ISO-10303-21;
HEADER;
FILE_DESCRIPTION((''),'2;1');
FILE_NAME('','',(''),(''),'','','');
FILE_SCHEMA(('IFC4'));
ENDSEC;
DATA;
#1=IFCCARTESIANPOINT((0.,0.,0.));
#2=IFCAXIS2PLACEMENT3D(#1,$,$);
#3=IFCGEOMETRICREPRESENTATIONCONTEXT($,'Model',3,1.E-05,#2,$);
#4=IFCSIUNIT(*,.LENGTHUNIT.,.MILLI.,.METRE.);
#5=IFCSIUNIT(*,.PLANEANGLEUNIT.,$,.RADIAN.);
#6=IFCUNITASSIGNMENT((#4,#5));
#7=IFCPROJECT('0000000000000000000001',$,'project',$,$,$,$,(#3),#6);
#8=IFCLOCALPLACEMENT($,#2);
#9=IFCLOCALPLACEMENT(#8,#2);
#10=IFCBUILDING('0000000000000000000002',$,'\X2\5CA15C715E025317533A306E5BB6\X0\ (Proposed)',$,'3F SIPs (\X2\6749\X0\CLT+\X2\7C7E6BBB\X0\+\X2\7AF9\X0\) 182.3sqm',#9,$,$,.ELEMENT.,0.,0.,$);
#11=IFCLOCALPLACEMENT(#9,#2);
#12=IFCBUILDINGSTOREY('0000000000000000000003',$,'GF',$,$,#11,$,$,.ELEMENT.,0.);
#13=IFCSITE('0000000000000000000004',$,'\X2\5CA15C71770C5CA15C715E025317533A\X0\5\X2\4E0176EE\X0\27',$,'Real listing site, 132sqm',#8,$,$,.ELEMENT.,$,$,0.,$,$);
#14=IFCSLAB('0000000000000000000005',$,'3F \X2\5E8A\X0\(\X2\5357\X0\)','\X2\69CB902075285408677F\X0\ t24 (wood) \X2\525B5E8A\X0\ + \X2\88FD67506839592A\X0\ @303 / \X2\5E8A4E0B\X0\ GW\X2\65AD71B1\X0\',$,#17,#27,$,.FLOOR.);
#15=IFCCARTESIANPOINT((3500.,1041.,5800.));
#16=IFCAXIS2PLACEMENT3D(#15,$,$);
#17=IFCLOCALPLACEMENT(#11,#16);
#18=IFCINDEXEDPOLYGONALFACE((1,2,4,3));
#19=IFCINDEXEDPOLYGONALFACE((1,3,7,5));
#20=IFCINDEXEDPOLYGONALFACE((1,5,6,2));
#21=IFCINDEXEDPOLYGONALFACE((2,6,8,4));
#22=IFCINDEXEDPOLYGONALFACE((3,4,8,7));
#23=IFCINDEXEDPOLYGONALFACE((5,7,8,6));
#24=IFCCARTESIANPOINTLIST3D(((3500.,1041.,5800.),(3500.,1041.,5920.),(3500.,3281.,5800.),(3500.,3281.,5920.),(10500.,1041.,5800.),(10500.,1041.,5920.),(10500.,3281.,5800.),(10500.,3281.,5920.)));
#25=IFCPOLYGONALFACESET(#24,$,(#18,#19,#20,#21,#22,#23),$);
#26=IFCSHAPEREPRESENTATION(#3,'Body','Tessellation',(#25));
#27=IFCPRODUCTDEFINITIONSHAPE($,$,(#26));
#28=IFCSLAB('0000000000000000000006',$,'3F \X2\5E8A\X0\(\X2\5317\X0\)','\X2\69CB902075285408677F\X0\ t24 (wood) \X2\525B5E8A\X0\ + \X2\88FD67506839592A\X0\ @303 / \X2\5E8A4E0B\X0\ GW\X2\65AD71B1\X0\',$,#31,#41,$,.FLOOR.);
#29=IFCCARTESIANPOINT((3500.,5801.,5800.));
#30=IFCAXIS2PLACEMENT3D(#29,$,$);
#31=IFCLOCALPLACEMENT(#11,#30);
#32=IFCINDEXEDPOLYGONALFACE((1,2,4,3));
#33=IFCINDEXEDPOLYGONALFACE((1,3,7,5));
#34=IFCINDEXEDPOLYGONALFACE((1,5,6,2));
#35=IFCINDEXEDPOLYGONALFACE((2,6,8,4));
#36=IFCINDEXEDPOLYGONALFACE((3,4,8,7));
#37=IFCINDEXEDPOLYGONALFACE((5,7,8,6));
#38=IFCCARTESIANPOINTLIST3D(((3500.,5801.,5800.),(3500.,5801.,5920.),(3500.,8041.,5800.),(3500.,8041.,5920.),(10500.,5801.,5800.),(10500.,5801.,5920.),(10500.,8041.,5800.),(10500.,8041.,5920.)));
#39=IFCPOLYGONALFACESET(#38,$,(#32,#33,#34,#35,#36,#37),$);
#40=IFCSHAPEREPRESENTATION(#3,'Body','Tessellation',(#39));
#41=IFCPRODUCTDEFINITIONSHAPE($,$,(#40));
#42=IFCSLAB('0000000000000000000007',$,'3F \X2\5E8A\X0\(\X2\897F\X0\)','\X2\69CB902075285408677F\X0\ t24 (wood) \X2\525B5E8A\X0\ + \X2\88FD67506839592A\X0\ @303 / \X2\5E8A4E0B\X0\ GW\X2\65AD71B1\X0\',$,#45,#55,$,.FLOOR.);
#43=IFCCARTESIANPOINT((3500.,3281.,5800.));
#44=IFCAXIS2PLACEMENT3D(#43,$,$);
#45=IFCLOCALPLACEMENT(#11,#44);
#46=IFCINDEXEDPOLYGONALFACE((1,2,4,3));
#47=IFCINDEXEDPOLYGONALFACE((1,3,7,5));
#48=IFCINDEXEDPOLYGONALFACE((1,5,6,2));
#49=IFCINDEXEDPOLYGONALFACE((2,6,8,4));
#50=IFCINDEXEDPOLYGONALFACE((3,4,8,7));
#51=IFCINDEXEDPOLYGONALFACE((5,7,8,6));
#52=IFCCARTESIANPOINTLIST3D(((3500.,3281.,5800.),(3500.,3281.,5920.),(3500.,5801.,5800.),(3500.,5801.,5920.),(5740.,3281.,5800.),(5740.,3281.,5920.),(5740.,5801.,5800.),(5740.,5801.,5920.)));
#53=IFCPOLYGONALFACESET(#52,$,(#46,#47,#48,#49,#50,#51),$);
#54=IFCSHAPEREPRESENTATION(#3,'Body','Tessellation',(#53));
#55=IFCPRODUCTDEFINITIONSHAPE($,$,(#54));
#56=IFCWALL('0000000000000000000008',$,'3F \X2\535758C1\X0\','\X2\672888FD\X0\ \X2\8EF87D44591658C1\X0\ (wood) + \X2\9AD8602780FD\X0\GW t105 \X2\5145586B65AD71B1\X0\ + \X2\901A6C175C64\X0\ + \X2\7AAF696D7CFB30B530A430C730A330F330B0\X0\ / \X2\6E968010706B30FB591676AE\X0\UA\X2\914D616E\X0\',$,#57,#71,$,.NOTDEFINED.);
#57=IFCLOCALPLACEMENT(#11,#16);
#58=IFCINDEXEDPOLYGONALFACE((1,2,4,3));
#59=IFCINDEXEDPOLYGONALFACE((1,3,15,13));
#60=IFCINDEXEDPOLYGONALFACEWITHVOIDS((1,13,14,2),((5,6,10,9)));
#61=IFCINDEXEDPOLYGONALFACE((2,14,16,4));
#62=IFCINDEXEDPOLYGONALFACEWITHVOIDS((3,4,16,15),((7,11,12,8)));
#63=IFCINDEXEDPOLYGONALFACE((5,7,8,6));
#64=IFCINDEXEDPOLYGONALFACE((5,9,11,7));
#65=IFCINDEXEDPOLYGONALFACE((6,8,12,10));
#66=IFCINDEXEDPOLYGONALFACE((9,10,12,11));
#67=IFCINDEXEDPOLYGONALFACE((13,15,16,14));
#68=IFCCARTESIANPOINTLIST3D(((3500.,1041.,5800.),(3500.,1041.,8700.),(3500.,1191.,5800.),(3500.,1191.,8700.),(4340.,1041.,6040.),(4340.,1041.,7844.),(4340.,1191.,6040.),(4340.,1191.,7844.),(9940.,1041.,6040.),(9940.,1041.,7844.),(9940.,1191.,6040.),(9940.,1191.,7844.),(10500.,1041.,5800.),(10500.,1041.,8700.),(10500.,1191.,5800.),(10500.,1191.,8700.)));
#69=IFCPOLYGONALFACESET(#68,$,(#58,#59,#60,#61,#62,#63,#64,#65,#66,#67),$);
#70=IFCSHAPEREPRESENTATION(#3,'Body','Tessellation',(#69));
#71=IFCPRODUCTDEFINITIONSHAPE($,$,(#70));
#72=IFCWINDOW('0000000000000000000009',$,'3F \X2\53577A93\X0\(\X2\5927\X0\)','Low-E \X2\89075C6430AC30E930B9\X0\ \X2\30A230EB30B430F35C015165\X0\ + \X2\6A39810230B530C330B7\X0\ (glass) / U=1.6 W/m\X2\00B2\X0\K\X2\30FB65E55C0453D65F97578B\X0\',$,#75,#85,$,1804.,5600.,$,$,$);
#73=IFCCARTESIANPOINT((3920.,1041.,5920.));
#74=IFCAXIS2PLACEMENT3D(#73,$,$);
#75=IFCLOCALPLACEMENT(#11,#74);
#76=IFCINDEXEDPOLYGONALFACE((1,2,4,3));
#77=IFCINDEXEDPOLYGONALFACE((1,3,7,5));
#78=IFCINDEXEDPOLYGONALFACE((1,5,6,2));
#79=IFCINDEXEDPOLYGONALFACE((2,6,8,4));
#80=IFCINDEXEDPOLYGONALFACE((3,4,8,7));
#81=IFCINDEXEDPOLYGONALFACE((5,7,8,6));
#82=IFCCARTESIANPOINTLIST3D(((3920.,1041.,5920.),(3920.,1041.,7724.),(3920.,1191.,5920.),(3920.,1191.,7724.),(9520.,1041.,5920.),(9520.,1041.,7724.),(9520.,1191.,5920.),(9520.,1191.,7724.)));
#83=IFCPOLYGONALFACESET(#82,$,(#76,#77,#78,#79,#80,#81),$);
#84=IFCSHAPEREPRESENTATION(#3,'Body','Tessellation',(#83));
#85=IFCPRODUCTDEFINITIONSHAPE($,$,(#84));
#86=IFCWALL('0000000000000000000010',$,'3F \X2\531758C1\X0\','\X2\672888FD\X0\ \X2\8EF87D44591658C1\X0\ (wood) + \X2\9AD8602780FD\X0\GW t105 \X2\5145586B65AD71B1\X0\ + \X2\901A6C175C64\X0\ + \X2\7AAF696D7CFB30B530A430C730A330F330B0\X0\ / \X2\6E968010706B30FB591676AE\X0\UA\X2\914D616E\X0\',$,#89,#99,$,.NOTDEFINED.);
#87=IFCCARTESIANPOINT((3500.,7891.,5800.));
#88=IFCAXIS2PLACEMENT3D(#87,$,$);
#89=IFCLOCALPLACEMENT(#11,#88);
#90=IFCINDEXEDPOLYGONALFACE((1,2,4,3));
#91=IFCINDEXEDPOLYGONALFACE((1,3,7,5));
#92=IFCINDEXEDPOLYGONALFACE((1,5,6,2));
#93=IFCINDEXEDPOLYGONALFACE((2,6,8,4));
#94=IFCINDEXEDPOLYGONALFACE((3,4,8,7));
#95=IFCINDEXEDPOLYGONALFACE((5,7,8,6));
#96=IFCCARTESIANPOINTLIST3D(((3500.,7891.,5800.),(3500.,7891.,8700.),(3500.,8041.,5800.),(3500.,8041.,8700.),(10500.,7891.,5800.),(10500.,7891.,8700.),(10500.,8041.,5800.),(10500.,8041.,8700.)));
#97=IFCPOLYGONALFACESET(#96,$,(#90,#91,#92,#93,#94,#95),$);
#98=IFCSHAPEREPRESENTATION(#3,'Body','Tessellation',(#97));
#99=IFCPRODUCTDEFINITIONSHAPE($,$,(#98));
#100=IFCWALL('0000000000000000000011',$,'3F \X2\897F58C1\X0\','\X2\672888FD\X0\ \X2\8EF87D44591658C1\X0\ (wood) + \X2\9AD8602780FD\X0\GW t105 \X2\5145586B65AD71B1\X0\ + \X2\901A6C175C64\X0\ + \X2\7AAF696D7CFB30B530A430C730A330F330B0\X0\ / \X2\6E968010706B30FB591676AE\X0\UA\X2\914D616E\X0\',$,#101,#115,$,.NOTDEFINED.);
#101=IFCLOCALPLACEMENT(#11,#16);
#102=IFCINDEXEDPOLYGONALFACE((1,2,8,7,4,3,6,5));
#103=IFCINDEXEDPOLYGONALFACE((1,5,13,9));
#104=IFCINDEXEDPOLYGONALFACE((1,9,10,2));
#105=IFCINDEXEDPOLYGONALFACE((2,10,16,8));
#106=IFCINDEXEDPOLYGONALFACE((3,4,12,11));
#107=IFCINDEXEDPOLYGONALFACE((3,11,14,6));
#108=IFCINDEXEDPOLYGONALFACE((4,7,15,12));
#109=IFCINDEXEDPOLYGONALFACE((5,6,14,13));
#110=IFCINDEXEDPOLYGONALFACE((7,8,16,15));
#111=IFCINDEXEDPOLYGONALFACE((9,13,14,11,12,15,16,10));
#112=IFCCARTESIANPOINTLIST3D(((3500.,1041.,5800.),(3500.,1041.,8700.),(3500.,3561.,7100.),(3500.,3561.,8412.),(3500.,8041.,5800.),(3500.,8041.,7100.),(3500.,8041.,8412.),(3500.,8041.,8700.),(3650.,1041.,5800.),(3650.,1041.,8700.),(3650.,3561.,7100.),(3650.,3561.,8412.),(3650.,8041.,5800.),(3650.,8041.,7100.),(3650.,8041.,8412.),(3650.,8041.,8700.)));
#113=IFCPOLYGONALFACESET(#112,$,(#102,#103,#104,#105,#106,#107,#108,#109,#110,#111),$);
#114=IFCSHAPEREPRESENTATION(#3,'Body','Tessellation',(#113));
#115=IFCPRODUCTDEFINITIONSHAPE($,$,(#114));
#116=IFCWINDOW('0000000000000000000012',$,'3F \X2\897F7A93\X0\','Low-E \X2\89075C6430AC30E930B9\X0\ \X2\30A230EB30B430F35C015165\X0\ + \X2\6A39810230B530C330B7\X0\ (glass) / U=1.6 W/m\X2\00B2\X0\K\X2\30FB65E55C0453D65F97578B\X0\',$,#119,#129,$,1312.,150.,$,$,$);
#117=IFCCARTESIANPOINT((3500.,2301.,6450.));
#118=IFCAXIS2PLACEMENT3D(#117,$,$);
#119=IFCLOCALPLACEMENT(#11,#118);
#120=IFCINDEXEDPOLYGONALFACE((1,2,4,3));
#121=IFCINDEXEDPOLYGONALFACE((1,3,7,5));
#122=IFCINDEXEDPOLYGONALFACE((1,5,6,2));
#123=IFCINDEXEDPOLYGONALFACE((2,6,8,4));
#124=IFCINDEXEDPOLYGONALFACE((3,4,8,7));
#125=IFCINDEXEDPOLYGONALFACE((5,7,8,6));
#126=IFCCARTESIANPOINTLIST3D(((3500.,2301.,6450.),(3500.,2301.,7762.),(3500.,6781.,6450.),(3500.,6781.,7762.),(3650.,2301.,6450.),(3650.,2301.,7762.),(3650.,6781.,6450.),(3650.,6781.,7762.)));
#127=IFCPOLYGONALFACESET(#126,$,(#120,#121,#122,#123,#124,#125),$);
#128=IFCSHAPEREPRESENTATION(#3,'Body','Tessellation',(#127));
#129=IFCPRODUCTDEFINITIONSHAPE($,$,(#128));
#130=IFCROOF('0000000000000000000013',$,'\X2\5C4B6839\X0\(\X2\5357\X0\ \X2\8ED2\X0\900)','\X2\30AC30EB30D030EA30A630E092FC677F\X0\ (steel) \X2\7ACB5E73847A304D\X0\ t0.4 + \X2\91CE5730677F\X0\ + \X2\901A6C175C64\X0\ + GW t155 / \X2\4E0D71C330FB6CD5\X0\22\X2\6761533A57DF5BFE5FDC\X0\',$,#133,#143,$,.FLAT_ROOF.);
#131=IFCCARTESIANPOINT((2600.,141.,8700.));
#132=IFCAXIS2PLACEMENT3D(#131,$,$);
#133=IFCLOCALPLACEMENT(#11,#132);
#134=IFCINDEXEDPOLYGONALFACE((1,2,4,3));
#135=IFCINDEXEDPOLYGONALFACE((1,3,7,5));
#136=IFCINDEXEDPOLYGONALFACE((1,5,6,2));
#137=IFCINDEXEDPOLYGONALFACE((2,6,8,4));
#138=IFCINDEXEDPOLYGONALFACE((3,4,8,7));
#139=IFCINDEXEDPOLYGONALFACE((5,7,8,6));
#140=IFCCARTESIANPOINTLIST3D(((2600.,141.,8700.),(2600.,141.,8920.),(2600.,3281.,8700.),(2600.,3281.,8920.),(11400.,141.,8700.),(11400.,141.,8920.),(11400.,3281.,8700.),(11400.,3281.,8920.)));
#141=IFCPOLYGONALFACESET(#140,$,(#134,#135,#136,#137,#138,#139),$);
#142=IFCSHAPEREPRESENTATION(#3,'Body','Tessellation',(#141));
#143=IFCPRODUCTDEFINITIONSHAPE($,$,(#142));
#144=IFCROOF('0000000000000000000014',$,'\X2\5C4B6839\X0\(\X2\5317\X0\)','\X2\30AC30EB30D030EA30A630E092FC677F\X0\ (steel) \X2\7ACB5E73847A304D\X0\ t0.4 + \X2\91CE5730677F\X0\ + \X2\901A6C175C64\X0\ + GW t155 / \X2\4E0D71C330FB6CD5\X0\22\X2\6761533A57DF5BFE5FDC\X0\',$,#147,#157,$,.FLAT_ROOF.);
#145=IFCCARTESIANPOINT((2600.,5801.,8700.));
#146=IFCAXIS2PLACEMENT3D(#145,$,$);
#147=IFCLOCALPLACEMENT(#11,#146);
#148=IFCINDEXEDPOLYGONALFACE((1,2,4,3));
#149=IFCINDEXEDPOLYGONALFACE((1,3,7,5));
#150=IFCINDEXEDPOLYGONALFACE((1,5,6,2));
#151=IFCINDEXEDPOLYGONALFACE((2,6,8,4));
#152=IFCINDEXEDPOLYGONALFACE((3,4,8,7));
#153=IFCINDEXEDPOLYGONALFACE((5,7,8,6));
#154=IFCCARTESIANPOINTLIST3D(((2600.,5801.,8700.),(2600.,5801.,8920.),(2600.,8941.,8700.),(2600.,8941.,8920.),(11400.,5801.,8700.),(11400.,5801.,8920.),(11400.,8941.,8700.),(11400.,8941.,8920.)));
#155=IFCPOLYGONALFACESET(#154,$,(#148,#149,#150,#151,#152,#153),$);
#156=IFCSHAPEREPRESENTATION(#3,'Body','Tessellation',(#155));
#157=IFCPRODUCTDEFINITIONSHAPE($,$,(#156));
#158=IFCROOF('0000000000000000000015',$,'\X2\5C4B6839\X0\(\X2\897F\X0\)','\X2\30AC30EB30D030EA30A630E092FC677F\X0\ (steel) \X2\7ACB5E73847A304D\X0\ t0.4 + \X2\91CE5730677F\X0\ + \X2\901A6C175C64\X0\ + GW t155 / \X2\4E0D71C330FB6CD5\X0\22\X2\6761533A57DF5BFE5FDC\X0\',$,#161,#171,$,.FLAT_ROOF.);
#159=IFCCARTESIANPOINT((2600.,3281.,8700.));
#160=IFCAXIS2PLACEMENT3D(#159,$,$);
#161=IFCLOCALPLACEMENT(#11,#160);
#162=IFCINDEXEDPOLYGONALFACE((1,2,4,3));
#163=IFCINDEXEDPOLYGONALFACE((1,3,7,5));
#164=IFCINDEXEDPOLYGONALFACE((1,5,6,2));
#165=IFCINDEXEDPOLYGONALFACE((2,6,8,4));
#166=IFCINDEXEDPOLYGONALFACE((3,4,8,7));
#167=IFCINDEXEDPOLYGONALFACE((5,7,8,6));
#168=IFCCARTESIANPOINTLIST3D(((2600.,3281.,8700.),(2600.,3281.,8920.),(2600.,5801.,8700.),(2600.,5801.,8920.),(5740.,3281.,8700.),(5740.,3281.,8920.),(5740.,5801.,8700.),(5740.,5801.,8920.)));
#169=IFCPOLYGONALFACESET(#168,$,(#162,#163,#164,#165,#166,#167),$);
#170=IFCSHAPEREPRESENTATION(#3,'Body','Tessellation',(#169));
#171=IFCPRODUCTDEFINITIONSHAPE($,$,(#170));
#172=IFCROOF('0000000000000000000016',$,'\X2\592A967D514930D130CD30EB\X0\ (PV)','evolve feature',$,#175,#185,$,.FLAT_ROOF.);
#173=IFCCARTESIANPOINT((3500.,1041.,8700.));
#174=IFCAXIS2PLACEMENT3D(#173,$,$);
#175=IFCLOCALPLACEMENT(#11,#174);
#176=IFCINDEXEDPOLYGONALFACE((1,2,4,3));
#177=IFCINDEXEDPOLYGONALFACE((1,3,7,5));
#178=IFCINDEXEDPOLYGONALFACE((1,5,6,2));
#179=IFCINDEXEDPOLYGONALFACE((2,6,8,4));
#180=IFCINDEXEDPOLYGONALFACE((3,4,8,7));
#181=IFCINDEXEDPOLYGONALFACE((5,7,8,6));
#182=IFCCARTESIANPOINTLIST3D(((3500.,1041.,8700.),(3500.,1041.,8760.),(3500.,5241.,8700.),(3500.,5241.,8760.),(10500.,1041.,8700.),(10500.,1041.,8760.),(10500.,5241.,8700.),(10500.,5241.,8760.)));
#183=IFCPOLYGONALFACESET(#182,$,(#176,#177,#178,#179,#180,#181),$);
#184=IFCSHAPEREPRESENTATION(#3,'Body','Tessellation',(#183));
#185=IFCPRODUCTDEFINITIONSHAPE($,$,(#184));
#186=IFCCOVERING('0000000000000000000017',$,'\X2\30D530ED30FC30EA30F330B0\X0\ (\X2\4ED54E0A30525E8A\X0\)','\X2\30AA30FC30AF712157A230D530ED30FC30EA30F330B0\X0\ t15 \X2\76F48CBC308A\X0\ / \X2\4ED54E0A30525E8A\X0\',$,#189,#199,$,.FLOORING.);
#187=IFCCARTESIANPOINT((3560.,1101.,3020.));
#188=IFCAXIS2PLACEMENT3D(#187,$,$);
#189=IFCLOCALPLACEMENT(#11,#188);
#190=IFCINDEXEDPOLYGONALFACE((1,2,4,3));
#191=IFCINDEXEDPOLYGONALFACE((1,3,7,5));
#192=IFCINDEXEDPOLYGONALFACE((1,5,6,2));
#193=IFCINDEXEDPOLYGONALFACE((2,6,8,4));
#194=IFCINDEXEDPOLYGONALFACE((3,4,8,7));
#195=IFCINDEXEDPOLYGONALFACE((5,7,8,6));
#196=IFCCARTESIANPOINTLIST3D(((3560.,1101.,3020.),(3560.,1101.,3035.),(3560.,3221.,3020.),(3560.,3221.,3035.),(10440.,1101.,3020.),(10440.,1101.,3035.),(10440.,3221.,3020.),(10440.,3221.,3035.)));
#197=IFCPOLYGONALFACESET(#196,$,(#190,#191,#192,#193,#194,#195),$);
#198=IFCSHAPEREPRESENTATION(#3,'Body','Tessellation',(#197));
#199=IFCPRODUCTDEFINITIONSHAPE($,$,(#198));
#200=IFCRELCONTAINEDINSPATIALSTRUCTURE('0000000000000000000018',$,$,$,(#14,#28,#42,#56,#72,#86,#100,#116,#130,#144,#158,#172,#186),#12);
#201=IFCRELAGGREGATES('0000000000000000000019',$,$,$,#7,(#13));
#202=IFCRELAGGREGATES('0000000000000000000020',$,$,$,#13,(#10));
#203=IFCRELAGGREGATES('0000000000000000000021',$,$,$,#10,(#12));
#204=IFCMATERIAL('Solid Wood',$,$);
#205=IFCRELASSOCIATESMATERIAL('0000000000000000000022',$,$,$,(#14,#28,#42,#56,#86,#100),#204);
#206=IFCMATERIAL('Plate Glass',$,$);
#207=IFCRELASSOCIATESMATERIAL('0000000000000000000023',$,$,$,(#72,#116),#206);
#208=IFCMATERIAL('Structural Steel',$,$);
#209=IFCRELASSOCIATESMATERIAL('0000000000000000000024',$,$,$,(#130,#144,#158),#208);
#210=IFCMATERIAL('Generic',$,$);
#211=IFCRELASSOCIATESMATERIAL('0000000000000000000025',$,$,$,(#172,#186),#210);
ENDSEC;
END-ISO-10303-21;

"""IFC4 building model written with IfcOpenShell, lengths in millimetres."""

from ifc_helpers import new_model, si_unit, frame, frame_2d, origin, place, context, project, spatial, rectangle, extrude, material, element, fill, save


model = new_model("IFC4")

# Units and contexts
model_context = context("Model", 3, precision=1e-05, world=origin())
ifc_project = project(units=[si_unit("LENGTHUNIT", "METRE", prefix="MILLI"), si_unit("PLANEANGLEUNIT", "RADIAN")], contexts=[model_context])

# Site, building, storey
site_placement = place(None, origin())
site = spatial("IfcSite", under=ifc_project, at=site_placement, Name="岡山県岡山市北区5丁目27", ObjectType="Real listing site, 132sqm", CompositionType="ELEMENT", RefElevation=0.0)
building_placement = place(site_placement, origin())
building = spatial("IfcBuilding", under=site, at=building_placement, Name="岡山市北区の家 (Proposed)", ObjectType="3F SIPs (杉CLT+籾殻+竹) 182.3sqm", CompositionType="ELEMENT", ElevationOfRefHeight=0.0, ElevationOfTerrain=0.0)
storey_placement = place(building_placement, origin())
storey = spatial("IfcBuildingStorey", under=building, at=storey_placement, Name="GF", CompositionType="ELEMENT", Elevation=0.0)

# Slabs
ifc_material_1 = material(Name="Solid Wood")
slab_1_placement = place(storey_placement, frame((3500.0, 1041.0, 5800.0)))
element("IfcSlab", 1, at=slab_1_placement, inside=storey, material=ifc_material_1, Name="3F 床(南)", Description="構造用合板 t24 (wood) 剛床 + 製材根太 @303 / 床下 GW断熱", PredefinedType="FLOOR", context=model_context, shape_type="SweptSolid", body=[
    extrude(rectangle(XDim=7000.0, YDim=2240.0, at=frame_2d((3500.0, 1120.0))), frame((3500.0, 1041.0, 5800.0)), (0.0, 0.0, 1.0), 120.0),
])
slab_2_placement = place(storey_placement, frame((3500.0, 5801.0, 5800.0)))
element("IfcSlab", 2, at=slab_2_placement, inside=storey, material=ifc_material_1, Name="3F 床(北)", Description="構造用合板 t24 (wood) 剛床 + 製材根太 @303 / 床下 GW断熱", PredefinedType="FLOOR", context=model_context, shape_type="SweptSolid", body=[
    extrude(rectangle(XDim=7000.0, YDim=2240.0, at=frame_2d((3500.0, 1120.0))), frame((3500.0, 5801.0, 5800.0)), (0.0, 0.0, 1.0), 120.0),
])
slab_3_placement = place(storey_placement, frame((3500.0, 3281.0, 5800.0)))
element("IfcSlab", 3, at=slab_3_placement, inside=storey, material=ifc_material_1, Name="3F 床(西)", Description="構造用合板 t24 (wood) 剛床 + 製材根太 @303 / 床下 GW断熱", PredefinedType="FLOOR", context=model_context, shape_type="SweptSolid", body=[
    extrude(rectangle(XDim=2240.0, YDim=2520.0, at=frame_2d((1120.0, 1260.0))), frame((3500.0, 3281.0, 5800.0)), (0.0, 0.0, 1.0), 120.0),
])

# Wall, opening, window
wall_1_placement = place(storey_placement, frame((3500.0, 1041.0, 5800.0)))
wall_1 = element("IfcWall", 4, at=wall_1_placement, inside=storey, material=ifc_material_1, Name="3F 南壁", Description="木製 軸組外壁 (wood) + 高性能GW t105 充填断熱 + 通気層 + 窯業系サイディング / 準耐火・外皮UA配慮", PredefinedType="NOTDEFINED", context=model_context, shape_type="SweptSolid", body=[
    extrude(rectangle(XDim=7000.0, YDim=150.0, at=frame_2d((3500.0, 75.0))), frame((3500.0, 1041.0, 5800.0)), (0.0, 0.0, 1.0), 2900.0),
])
opening_1_placement = place(storey_placement, frame((3920.0, 1041.0, 5920.0)))
opening_1 = element("IfcOpeningElement", 5, at=opening_1_placement, cuts=wall_1, PredefinedType="NOTDEFINED", context=model_context, shape_type="SweptSolid", body=[
    extrude(rectangle(XDim=5600.0, YDim=150.0, at=frame_2d((2800.0, 75.0))), frame((3920.0, 1041.0, 5920.0)), (0.0, 0.0, 1.0), 1804.0),
])
ifc_material_2 = material(Name="Plate Glass")
window_1_placement = place(storey_placement, frame((3920.0, 1041.0, 5920.0)))
window_1 = element("IfcWindow", 6, at=window_1_placement, inside=storey, material=ifc_material_2, Name="3F 南窓(大)", Description="Low-E 複層ガラス アルゴン封入 + 樹脂サッシ (glass) / U=1.6 W/m²K・日射取得型", OverallHeight=1804.0, OverallWidth=5600.0, context=model_context, shape_type="SweptSolid", body=[
    extrude(rectangle(XDim=5600.0, YDim=150.0, at=frame_2d((2800.0, 75.0))), frame((3920.0, 1041.0, 5920.0)), (0.0, 0.0, 1.0), 1804.0),
])
fill(opening_1, window_1)

# Wall
wall_2_placement = place(storey_placement, frame((3500.0, 7891.0, 5800.0)))
element("IfcWall", 7, at=wall_2_placement, inside=storey, material=ifc_material_1, Name="3F 北壁", Description="木製 軸組外壁 (wood) + 高性能GW t105 充填断熱 + 通気層 + 窯業系サイディング / 準耐火・外皮UA配慮", PredefinedType="NOTDEFINED", context=model_context, shape_type="SweptSolid", body=[
    extrude(rectangle(XDim=7000.0, YDim=150.0, at=frame_2d((3500.0, 75.0))), frame((3500.0, 7891.0, 5800.0)), (0.0, 0.0, 1.0), 2900.0),
])

# Wall, opening, window
wall_3_placement = place(storey_placement, frame((3500.0, 1041.0, 5800.0)))
wall_3 = element("IfcWall", 8, at=wall_3_placement, inside=storey, material=ifc_material_1, Name="3F 西壁", Description="木製 軸組外壁 (wood) + 高性能GW t105 充填断熱 + 通気層 + 窯業系サイディング / 準耐火・外皮UA配慮", PredefinedType="NOTDEFINED", context=model_context, shape_type="SweptSolid", body=[
    extrude(rectangle(XDim=150.0, YDim=7000.0, at=frame_2d((75.0, 3500.0))), frame((3500.0, 1041.0, 5800.0)), (0.0, 0.0, 1.0), 2900.0),
])
opening_2_placement = place(storey_placement, frame((3500.0, 2301.0, 6450.0)))
opening_2 = element("IfcOpeningElement", 9, at=opening_2_placement, cuts=wall_3, PredefinedType="NOTDEFINED", context=model_context, shape_type="SweptSolid", body=[
    extrude(rectangle(XDim=150.0, YDim=4480.0, at=frame_2d((75.0, 2240.0))), frame((3500.0, 2301.0, 6450.0)), (0.0, 0.0, 1.0), 1312.0),
])
window_2_placement = place(storey_placement, frame((3500.0, 2301.0, 6450.0)))
window_2 = element("IfcWindow", 10, at=window_2_placement, inside=storey, material=ifc_material_2, Name="3F 西窓", Description="Low-E 複層ガラス アルゴン封入 + 樹脂サッシ (glass) / U=1.6 W/m²K・日射取得型", OverallHeight=1312.0, OverallWidth=150.0, context=model_context, shape_type="SweptSolid", body=[
    extrude(rectangle(XDim=150.0, YDim=4480.0, at=frame_2d((75.0, 2240.0))), frame((3500.0, 2301.0, 6450.0)), (0.0, 0.0, 1.0), 1312.0),
])
fill(opening_2, window_2)

# Roofs
ifc_material_3 = material(Name="Structural Steel")
roof_1_placement = place(storey_placement, frame((2600.0, 141.0, 8700.0)))
element("IfcRoof", 11, at=roof_1_placement, inside=storey, material=ifc_material_3, Name="屋根(南 軒900)", Description="ガルバリウム鋼板 (steel) 立平葺き t0.4 + 野地板 + 通気層 + GW t155 / 不燃・法22条区域対応", PredefinedType="FLAT_ROOF", context=model_context, shape_type="SweptSolid", body=[
    extrude(rectangle(XDim=8800.0, YDim=3140.0, at=frame_2d((4400.0, 1570.0))), frame((2600.0, 141.0, 8700.0)), (0.0, 0.0, 1.0), 220.0),
])
roof_2_placement = place(storey_placement, frame((2600.0, 5801.0, 8700.0)))
element("IfcRoof", 12, at=roof_2_placement, inside=storey, material=ifc_material_3, Name="屋根(北)", Description="ガルバリウム鋼板 (steel) 立平葺き t0.4 + 野地板 + 通気層 + GW t155 / 不燃・法22条区域対応", PredefinedType="FLAT_ROOF", context=model_context, shape_type="SweptSolid", body=[
    extrude(rectangle(XDim=8800.0, YDim=3140.0, at=frame_2d((4400.0, 1570.0))), frame((2600.0, 5801.0, 8700.0)), (0.0, 0.0, 1.0), 220.0),
])
roof_3_placement = place(storey_placement, frame((2600.0, 3281.0, 8700.0)))
element("IfcRoof", 13, at=roof_3_placement, inside=storey, material=ifc_material_3, Name="屋根(西)", Description="ガルバリウム鋼板 (steel) 立平葺き t0.4 + 野地板 + 通気層 + GW t155 / 不燃・法22条区域対応", PredefinedType="FLAT_ROOF", context=model_context, shape_type="SweptSolid", body=[
    extrude(rectangle(XDim=3140.0, YDim=2520.0, at=frame_2d((1570.0, 1260.0))), frame((2600.0, 3281.0, 8700.0)), (0.0, 0.0, 1.0), 220.0),
])
ifc_material_4 = material(Name="Generic")
roof_4_placement = place(storey_placement, frame((3500.0, 1041.0, 8700.0)))
element("IfcRoof", 14, at=roof_4_placement, inside=storey, material=ifc_material_4, Name="太陽光パネル (PV)", Description="evolve feature", PredefinedType="FLAT_ROOF", context=model_context, shape_type="SweptSolid", body=[
    extrude(rectangle(XDim=7000.0, YDim=4200.0, at=frame_2d((3500.0, 2100.0))), frame((3500.0, 1041.0, 8700.0)), (0.0, 0.0, 1.0), 60.0),
])

# Covering
covering_1_placement = place(storey_placement, frame((3560.0, 1101.0, 3020.0)))
element("IfcCovering", 15, at=covering_1_placement, inside=storey, material=ifc_material_4, Name="フローリング (仕上げ床)", Description="オーク無垢フローリング t15 直貼り / 仕上げ床", PredefinedType="FLOORING", context=model_context, shape_type="SweptSolid", body=[
    extrude(rectangle(XDim=6880.0, YDim=2120.0, at=frame_2d((3440.0, 1060.0))), frame((3560.0, 1101.0, 3020.0)), (0.0, 0.0, 1.0), 15.0),
])

save(model, "model.ifc")
